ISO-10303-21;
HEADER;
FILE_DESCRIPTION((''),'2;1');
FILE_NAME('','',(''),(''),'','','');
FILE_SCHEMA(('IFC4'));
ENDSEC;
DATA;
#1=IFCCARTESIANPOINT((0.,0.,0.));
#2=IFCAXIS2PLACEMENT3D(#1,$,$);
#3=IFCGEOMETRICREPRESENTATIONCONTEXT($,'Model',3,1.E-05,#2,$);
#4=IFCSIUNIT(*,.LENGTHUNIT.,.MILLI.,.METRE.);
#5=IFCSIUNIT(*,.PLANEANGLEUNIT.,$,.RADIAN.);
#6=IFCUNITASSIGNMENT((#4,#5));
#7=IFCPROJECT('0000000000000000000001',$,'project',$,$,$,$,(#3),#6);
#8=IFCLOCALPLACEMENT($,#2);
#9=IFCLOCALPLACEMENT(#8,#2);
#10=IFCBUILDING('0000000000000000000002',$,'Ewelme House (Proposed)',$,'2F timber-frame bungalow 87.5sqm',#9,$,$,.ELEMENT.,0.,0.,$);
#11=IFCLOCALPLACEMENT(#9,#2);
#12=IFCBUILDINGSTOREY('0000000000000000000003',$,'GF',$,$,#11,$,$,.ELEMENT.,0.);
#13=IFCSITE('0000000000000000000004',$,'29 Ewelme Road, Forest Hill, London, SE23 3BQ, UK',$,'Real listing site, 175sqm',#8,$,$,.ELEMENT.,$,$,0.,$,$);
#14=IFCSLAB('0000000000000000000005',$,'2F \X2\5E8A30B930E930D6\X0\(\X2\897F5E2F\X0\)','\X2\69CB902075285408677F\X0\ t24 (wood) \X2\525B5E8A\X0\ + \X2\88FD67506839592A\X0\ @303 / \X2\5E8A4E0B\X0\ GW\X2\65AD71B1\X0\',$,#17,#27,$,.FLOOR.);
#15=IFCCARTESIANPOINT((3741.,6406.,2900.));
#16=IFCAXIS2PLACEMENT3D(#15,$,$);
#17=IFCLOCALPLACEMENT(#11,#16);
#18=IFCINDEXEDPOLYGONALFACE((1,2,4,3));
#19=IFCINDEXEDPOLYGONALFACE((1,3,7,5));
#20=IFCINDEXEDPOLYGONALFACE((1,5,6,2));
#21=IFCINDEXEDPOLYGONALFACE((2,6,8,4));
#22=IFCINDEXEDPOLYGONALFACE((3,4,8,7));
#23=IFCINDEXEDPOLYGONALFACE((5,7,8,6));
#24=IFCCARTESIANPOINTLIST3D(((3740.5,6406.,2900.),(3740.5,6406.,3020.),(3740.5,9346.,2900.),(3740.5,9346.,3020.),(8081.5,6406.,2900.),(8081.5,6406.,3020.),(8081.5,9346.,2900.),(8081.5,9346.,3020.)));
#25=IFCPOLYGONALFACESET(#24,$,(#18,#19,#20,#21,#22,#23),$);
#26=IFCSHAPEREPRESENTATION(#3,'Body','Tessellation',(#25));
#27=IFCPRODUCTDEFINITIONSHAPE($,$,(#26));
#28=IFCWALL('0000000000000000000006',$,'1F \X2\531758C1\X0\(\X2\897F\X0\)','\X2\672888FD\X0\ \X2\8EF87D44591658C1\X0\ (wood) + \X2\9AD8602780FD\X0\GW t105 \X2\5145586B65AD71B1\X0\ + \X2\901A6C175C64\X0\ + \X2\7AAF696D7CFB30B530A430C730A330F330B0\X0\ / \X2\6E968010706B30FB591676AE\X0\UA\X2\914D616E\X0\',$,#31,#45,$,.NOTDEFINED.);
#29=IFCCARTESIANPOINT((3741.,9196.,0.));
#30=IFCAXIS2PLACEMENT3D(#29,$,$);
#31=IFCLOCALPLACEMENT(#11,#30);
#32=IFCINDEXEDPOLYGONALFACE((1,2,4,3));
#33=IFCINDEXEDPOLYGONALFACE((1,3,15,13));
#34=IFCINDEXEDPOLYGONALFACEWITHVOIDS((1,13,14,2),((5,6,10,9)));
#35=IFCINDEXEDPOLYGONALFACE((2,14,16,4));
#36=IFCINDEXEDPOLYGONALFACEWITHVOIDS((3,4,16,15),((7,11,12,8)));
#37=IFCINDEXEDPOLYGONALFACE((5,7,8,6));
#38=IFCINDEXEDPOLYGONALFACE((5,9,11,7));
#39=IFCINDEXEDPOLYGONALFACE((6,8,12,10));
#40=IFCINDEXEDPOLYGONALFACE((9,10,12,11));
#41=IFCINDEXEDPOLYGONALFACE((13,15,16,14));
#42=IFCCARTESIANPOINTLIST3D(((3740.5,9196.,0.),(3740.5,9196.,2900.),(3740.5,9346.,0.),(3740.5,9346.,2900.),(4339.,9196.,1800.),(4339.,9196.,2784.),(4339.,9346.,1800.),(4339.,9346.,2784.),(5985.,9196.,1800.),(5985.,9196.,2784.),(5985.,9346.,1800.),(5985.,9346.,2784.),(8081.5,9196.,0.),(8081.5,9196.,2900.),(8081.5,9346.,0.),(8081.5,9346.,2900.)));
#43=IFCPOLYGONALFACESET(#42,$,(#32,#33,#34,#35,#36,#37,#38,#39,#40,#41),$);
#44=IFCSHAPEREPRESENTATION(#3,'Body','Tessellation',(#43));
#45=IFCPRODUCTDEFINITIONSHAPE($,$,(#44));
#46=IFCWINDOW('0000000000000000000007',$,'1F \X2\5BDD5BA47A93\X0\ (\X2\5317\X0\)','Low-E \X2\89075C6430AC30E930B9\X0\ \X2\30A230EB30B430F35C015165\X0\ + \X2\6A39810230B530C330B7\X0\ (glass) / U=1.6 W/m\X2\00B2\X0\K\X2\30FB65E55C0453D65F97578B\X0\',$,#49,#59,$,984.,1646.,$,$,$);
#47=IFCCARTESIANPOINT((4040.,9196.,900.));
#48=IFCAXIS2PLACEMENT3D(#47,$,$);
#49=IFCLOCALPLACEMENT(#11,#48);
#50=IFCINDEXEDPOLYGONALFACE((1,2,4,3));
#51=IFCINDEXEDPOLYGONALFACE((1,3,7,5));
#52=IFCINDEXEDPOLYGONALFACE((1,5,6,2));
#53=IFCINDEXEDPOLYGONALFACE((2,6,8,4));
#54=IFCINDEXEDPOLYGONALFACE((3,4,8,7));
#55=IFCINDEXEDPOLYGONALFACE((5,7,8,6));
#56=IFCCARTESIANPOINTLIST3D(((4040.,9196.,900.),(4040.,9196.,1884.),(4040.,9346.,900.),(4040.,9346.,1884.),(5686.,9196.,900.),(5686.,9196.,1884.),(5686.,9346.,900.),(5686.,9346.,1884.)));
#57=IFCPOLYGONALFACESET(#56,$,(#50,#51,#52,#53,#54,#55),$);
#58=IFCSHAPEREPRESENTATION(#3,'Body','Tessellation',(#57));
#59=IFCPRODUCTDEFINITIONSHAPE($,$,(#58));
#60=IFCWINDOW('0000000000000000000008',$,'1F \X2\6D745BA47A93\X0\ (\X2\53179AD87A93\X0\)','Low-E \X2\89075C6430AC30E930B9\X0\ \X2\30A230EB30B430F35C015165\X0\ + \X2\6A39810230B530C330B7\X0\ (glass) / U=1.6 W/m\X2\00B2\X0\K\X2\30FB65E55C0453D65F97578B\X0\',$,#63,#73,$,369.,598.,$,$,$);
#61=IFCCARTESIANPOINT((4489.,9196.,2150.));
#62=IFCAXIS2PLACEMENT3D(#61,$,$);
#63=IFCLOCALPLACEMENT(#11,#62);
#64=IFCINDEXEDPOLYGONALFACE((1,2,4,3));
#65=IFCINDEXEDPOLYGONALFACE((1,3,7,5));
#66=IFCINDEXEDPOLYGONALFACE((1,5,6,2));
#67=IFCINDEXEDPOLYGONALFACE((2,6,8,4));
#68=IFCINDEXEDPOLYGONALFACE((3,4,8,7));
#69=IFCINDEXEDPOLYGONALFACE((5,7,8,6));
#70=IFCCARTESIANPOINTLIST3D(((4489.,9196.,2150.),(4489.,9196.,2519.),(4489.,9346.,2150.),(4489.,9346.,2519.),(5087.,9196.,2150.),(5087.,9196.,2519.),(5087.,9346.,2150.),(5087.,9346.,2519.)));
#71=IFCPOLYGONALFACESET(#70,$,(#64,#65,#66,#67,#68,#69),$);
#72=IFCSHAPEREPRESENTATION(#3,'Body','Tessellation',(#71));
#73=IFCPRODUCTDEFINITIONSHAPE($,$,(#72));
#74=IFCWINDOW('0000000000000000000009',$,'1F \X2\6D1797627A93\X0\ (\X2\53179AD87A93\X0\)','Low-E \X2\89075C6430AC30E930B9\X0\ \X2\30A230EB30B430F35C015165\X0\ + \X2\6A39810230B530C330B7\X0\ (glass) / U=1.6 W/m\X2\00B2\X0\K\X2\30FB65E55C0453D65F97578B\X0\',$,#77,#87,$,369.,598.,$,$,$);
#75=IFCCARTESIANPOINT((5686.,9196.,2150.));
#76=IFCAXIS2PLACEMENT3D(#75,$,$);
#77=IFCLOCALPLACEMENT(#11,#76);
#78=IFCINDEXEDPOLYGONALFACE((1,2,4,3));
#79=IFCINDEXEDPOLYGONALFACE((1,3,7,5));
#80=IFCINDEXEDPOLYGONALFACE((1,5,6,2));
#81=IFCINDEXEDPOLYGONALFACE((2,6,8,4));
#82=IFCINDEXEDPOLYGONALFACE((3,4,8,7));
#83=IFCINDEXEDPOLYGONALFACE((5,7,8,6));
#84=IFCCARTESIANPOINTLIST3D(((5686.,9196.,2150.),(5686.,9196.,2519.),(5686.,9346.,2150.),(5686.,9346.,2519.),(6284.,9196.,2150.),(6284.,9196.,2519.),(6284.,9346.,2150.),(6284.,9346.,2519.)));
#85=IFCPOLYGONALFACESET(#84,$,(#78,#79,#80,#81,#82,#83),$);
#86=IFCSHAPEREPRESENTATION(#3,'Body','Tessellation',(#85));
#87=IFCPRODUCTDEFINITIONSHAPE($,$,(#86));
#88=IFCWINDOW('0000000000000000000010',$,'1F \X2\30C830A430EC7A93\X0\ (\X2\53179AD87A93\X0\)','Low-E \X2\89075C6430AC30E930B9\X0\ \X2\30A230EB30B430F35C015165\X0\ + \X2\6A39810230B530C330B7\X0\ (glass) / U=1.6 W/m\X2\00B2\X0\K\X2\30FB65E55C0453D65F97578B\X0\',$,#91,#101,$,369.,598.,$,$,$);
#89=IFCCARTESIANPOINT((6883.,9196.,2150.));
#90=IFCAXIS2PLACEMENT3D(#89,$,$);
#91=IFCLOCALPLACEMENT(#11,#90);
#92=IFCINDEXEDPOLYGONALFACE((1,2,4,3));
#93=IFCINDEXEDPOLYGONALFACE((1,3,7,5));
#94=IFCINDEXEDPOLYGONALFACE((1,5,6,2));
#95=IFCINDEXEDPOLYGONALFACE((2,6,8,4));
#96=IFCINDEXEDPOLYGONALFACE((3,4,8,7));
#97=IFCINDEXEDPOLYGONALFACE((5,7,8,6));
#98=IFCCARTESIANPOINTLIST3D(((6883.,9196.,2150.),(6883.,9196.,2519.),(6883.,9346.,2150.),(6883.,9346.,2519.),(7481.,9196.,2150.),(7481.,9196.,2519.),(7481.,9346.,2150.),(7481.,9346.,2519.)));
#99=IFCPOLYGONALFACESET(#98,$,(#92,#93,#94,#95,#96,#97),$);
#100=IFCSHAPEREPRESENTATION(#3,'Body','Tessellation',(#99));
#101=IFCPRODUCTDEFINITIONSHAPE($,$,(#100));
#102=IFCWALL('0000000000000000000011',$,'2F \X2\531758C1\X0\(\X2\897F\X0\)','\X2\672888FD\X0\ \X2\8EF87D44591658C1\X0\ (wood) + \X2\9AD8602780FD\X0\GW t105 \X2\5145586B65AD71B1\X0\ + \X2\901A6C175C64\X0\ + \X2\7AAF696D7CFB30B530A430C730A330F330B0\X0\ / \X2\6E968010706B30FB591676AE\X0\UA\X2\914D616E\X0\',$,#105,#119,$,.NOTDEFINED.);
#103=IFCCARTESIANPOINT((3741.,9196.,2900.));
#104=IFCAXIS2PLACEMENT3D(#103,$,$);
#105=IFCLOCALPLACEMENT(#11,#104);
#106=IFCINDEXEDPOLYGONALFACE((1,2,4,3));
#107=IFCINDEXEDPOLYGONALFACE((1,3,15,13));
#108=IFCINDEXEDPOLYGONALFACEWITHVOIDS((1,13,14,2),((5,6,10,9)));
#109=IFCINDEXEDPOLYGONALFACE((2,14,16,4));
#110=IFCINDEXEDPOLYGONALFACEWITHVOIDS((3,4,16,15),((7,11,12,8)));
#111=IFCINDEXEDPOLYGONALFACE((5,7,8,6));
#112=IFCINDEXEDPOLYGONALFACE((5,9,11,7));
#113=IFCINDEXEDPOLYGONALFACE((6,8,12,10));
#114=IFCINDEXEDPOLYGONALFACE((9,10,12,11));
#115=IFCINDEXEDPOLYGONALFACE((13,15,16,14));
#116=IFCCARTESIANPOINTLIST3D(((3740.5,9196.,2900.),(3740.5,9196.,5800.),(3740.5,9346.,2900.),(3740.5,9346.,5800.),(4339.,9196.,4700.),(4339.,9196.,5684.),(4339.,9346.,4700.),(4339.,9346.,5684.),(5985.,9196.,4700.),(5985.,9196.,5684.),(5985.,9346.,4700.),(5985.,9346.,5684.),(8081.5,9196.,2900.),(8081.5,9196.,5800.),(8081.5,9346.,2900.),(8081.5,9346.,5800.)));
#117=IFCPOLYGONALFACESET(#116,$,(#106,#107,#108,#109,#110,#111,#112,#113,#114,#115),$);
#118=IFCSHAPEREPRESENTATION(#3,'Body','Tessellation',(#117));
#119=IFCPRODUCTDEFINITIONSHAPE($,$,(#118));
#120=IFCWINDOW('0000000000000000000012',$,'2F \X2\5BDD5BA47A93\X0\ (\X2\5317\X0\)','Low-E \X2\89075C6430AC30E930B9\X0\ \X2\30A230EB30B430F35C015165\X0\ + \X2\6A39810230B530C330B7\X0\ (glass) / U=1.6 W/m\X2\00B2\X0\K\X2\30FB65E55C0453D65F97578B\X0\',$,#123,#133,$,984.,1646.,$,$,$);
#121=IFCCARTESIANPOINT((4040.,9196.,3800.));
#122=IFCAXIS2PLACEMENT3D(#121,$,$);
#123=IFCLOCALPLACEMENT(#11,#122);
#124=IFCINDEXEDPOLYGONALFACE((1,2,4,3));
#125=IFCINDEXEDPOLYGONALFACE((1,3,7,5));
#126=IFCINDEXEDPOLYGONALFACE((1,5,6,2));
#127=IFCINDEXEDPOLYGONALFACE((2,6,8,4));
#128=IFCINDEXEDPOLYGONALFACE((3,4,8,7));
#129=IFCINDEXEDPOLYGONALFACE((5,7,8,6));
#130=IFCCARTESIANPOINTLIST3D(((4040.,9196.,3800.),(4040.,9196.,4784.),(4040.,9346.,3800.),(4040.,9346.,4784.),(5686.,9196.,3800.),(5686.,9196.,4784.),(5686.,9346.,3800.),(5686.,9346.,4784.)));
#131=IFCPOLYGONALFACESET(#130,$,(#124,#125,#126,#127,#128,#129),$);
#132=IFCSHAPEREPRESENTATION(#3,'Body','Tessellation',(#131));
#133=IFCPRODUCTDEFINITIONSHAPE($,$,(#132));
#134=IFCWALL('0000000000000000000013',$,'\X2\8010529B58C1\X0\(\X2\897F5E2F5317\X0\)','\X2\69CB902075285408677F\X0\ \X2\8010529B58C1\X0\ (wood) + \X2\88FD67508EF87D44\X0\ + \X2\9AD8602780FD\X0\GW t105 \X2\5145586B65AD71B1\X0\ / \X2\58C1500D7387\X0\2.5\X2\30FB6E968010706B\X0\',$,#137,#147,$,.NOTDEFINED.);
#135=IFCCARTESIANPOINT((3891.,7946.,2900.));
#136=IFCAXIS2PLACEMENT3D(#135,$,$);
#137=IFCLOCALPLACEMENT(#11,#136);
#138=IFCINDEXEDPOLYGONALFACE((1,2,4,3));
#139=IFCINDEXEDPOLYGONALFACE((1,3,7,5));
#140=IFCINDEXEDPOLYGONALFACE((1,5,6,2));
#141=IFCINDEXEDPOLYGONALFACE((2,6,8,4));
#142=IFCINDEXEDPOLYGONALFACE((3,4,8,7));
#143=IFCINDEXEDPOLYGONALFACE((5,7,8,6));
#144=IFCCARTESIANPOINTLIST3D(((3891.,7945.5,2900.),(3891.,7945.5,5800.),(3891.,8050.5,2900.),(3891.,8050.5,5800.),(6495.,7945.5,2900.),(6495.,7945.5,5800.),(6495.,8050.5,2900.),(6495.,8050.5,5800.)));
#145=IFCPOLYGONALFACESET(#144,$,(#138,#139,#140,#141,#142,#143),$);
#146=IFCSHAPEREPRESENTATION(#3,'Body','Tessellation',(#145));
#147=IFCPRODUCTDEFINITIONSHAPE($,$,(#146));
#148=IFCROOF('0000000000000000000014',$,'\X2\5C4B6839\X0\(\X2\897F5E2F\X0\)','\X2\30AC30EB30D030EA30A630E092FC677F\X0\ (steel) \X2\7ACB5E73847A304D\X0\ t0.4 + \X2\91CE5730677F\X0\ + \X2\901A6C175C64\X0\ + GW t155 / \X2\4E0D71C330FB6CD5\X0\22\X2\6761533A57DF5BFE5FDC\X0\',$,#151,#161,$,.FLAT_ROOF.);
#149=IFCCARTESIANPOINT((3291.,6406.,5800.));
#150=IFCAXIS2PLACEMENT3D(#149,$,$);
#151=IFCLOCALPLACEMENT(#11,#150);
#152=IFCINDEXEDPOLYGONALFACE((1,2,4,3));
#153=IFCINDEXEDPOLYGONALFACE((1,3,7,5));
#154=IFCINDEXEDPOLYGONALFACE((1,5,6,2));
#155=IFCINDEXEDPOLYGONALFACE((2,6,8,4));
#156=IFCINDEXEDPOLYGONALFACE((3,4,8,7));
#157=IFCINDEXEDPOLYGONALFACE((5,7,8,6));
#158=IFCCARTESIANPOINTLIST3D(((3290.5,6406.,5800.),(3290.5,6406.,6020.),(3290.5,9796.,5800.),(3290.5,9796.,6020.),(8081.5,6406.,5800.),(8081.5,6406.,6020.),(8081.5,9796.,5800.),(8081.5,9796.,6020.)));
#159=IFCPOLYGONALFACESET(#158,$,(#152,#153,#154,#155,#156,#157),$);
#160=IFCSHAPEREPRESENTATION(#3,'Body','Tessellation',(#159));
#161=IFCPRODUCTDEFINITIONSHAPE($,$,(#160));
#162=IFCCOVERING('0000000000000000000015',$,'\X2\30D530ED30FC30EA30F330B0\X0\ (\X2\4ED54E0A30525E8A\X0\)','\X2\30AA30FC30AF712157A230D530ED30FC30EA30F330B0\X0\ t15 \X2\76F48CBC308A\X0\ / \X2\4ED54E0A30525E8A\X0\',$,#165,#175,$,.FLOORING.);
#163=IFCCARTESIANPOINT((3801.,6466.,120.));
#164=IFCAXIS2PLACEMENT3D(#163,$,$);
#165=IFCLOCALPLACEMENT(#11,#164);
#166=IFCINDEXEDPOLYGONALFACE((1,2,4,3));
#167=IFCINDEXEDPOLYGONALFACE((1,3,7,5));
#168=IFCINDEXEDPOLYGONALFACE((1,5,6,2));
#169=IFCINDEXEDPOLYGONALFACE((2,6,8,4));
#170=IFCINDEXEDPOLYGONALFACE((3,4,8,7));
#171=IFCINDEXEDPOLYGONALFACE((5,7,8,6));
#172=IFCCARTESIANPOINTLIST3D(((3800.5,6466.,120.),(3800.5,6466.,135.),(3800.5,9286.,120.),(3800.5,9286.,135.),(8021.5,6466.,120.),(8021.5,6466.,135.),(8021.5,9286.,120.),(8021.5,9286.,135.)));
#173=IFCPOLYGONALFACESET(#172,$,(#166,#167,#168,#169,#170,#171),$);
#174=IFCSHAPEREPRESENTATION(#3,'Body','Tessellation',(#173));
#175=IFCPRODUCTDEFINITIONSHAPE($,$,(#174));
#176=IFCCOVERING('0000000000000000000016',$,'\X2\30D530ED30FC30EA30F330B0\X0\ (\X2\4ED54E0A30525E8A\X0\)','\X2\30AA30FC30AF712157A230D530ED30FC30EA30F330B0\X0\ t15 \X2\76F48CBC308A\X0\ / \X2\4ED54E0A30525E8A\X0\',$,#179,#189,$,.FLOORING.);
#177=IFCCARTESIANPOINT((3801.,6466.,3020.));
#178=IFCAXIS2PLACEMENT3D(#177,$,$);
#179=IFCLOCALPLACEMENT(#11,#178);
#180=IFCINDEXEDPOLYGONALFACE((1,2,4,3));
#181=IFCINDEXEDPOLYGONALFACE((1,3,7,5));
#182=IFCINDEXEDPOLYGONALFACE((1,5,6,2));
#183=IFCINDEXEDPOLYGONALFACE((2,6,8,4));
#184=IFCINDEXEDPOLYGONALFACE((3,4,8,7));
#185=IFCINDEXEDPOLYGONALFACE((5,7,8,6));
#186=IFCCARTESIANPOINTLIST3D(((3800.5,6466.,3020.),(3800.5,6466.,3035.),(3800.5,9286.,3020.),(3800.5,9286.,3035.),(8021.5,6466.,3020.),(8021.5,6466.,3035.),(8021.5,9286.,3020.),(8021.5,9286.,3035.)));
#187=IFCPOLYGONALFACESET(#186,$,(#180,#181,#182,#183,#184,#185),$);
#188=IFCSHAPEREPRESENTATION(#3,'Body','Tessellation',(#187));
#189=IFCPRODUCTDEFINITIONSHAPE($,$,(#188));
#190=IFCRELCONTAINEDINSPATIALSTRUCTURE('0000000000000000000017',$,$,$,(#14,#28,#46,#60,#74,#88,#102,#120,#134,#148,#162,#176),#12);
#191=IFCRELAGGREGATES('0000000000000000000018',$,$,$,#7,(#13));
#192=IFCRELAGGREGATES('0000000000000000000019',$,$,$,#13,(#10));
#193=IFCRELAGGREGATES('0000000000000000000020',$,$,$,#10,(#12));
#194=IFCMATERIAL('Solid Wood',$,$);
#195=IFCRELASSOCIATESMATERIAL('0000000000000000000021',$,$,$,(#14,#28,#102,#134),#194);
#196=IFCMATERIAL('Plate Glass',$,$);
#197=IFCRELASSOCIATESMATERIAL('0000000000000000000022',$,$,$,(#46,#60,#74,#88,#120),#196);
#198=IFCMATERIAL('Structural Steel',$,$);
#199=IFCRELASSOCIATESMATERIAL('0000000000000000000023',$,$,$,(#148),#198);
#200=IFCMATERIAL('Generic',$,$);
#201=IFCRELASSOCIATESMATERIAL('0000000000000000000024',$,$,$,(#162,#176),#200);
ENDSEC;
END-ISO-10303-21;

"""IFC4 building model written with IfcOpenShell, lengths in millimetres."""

from ifc_helpers import new_model, si_unit, frame, frame_2d, origin, place, context, project, spatial, rectangle, extrude, material, element, fill, save


model = new_model("IFC4")

# Units and contexts
model_context = context("Model", 3, precision=1e-05, world=origin())
ifc_project = project(units=[si_unit("LENGTHUNIT", "METRE", prefix="MILLI"), si_unit("PLANEANGLEUNIT", "RADIAN")], contexts=[model_context])

# Site, building, storey
site_placement = place(None, origin())
site = spatial("IfcSite", under=ifc_project, at=site_placement, Name="29 Ewelme Road, Forest Hill, London, SE23 3BQ, UK", ObjectType="Real listing site, 175sqm", CompositionType="ELEMENT", RefElevation=0.0)
building_placement = place(site_placement, origin())
building = spatial("IfcBuilding", under=site, at=building_placement, Name="Ewelme House (Proposed)", ObjectType="2F timber-frame bungalow 87.5sqm", CompositionType="ELEMENT", ElevationOfRefHeight=0.0, ElevationOfTerrain=0.0)
storey_placement = place(building_placement, origin())
storey = spatial("IfcBuildingStorey", under=building, at=storey_placement, Name="GF", CompositionType="ELEMENT", Elevation=0.0)

# Slab
ifc_material_1 = material(Name="Solid Wood")
slab_1_placement = place(storey_placement, frame((3741.0, 6406.0, 2900.0)))
element("IfcSlab", 1, at=slab_1_placement, inside=storey, material=ifc_material_1, Name="2F 床スラブ(西帯)", Description="構造用合板 t24 (wood) 剛床 + 製材根太 @303 / 床下 GW断熱", PredefinedType="FLOOR", context=model_context, shape_type="SweptSolid", body=[
    extrude(rectangle(XDim=4341.0, YDim=2940.0, at=frame_2d((2170.0, 1470.0))), frame((3741.0, 6406.0, 2900.0)), (0.0, 0.0, 1.0), 120.0),
])

# Wall, openings, windows
wall_1_placement = place(storey_placement, frame((3741.0, 9196.0, 0.0)))
wall_1 = element("IfcWall", 2, at=wall_1_placement, inside=storey, material=ifc_material_1, Name="1F 北壁(西)", Description="木製 軸組外壁 (wood) + 高性能GW t105 充填断熱 + 通気層 + 窯業系サイディング / 準耐火・外皮UA配慮", PredefinedType="NOTDEFINED", context=model_context, shape_type="SweptSolid", body=[
    extrude(rectangle(XDim=4341.0, YDim=150.0, at=frame_2d((2170.0, 75.0))), frame((3741.0, 9196.0, 0.0)), (0.0, 0.0, 1.0), 2900.0),
])
opening_1_placement = place(storey_placement, frame((4040.0, 9196.0, 900.0)))
opening_1 = element("IfcOpeningElement", 3, at=opening_1_placement, cuts=wall_1, PredefinedType="NOTDEFINED", context=model_context, shape_type="SweptSolid", body=[
    extrude(rectangle(XDim=1646.0, YDim=150.0, at=frame_2d((823.0, 75.0))), frame((4040.0, 9196.0, 900.0)), (0.0, 0.0, 1.0), 984.0),
])
opening_2_placement = place(storey_placement, frame((4489.0, 9196.0, 2150.0)))
opening_2 = element("IfcOpeningElement", 4, at=opening_2_placement, cuts=wall_1, PredefinedType="NOTDEFINED", context=model_context, shape_type="SweptSolid", body=[
    extrude(rectangle(XDim=598.0, YDim=150.0, at=frame_2d((299.0, 75.0))), frame((4489.0, 9196.0, 2150.0)), (0.0, 0.0, 1.0), 369.0),
])
opening_3_placement = place(storey_placement, frame((5686.0, 9196.0, 2150.0)))
opening_3 = element("IfcOpeningElement", 5, at=opening_3_placement, cuts=wall_1, PredefinedType="NOTDEFINED", context=model_context, shape_type="SweptSolid", body=[
    extrude(rectangle(XDim=598.0, YDim=150.0, at=frame_2d((299.0, 75.0))), frame((5686.0, 9196.0, 2150.0)), (0.0, 0.0, 1.0), 369.0),
])
opening_4_placement = place(storey_placement, frame((6883.0, 9196.0, 2150.0)))
opening_4 = element("IfcOpeningElement", 6, at=opening_4_placement, cuts=wall_1, PredefinedType="NOTDEFINED", context=model_context, shape_type="SweptSolid", body=[
    extrude(rectangle(XDim=598.0, YDim=150.0, at=frame_2d((299.0, 75.0))), frame((6883.0, 9196.0, 2150.0)), (0.0, 0.0, 1.0), 369.0),
])
ifc_material_2 = material(Name="Plate Glass")
window_1_placement = place(storey_placement, frame((4040.0, 9196.0, 900.0)))
window_1 = element("IfcWindow", 7, at=window_1_placement, inside=storey, material=ifc_material_2, Name="1F 寝室窓 (北)", Description="Low-E 複層ガラス アルゴン封入 + 樹脂サッシ (glass) / U=1.6 W/m²K・日射取得型", OverallHeight=984.0, OverallWidth=1646.0, context=model_context, shape_type="SweptSolid", body=[
    extrude(rectangle(XDim=1646.0, YDim=150.0, at=frame_2d((823.0, 75.0))), frame((4040.0, 9196.0, 900.0)), (0.0, 0.0, 1.0), 984.0),
])
fill(opening_1, window_1)
window_2_placement = place(storey_placement, frame((4489.0, 9196.0, 2150.0)))
window_2 = element("IfcWindow", 8, at=window_2_placement, inside=storey, material=ifc_material_2, Name="1F 浴室窓 (北高窓)", Description="Low-E 複層ガラス アルゴン封入 + 樹脂サッシ (glass) / U=1.6 W/m²K・日射取得型", OverallHeight=369.0, OverallWidth=598.0, context=model_context, shape_type="SweptSolid", body=[
    extrude(rectangle(XDim=598.0, YDim=150.0, at=frame_2d((299.0, 75.0))), frame((4489.0, 9196.0, 2150.0)), (0.0, 0.0, 1.0), 369.0),
])
fill(opening_2, window_2)
window_3_placement = place(storey_placement, frame((5686.0, 9196.0, 2150.0)))
window_3 = element("IfcWindow", 9, at=window_3_placement, inside=storey, material=ifc_material_2, Name="1F 洗面窓 (北高窓)", Description="Low-E 複層ガラス アルゴン封入 + 樹脂サッシ (glass) / U=1.6 W/m²K・日射取得型", OverallHeight=369.0, OverallWidth=598.0, context=model_context, shape_type="SweptSolid", body=[
    extrude(rectangle(XDim=598.0, YDim=150.0, at=frame_2d((299.0, 75.0))), frame((5686.0, 9196.0, 2150.0)), (0.0, 0.0, 1.0), 369.0),
])
fill(opening_3, window_3)
window_4_placement = place(storey_placement, frame((6883.0, 9196.0, 2150.0)))
window_4 = element("IfcWindow", 10, at=window_4_placement, inside=storey, material=ifc_material_2, Name="1F トイレ窓 (北高窓)", Description="Low-E 複層ガラス アルゴン封入 + 樹脂サッシ (glass) / U=1.6 W/m²K・日射取得型", OverallHeight=369.0, OverallWidth=598.0, context=model_context, shape_type="SweptSolid", body=[
    extrude(rectangle(XDim=598.0, YDim=150.0, at=frame_2d((299.0, 75.0))), frame((6883.0, 9196.0, 2150.0)), (0.0, 0.0, 1.0), 369.0),
])
fill(opening_4, window_4)

# Wall, opening, window
wall_2_placement = place(storey_placement, frame((3741.0, 9196.0, 2900.0)))
wall_2 = element("IfcWall", 11, at=wall_2_placement, inside=storey, material=ifc_material_1, Name="2F 北壁(西)", Description="木製 軸組外壁 (wood) + 高性能GW t105 充填断熱 + 通気層 + 窯業系サイディング / 準耐火・外皮UA配慮", PredefinedType="NOTDEFINED", context=model_context, shape_type="SweptSolid", body=[
    extrude(rectangle(XDim=4341.0, YDim=150.0, at=frame_2d((2170.0, 75.0))), frame((3741.0, 9196.0, 2900.0)), (0.0, 0.0, 1.0), 2900.0),
])
opening_5_placement = place(storey_placement, frame((4040.0, 9196.0, 3800.0)))
opening_5 = element("IfcOpeningElement", 12, at=opening_5_placement, cuts=wall_2, PredefinedType="NOTDEFINED", context=model_context, shape_type="SweptSolid", body=[
    extrude(rectangle(XDim=1646.0, YDim=150.0, at=frame_2d((823.0, 75.0))), frame((4040.0, 9196.0, 3800.0)), (0.0, 0.0, 1.0), 984.0),
])
window_5_placement = place(storey_placement, frame((4040.0, 9196.0, 3800.0)))
window_5 = element("IfcWindow", 13, at=window_5_placement, inside=storey, material=ifc_material_2, Name="2F 寝室窓 (北)", Description="Low-E 複層ガラス アルゴン封入 + 樹脂サッシ (glass) / U=1.6 W/m²K・日射取得型", OverallHeight=984.0, OverallWidth=1646.0, context=model_context, shape_type="SweptSolid", body=[
    extrude(rectangle(XDim=1646.0, YDim=150.0, at=frame_2d((823.0, 75.0))), frame((4040.0, 9196.0, 3800.0)), (0.0, 0.0, 1.0), 984.0),
])
fill(opening_5, window_5)

# Wall
wall_3_placement = place(storey_placement, frame((3891.0, 7946.0, 2900.0)))
element("IfcWall", 14, at=wall_3_placement, inside=storey, material=ifc_material_1, Name="耐力壁(西帯北)", Description="構造用合板 耐力壁 (wood) + 製材軸組 + 高性能GW t105 充填断熱 / 壁倍率2.5・準耐火", PredefinedType="NOTDEFINED", context=model_context, shape_type="SweptSolid", body=[
    extrude(rectangle(XDim=2604.0, YDim=105.0, at=frame_2d((1302.0, 52.0))), frame((3891.0, 7946.0, 2900.0)), (0.0, 0.0, 1.0), 2900.0),
])

# Roof
ifc_material_3 = material(Name="Structural Steel")
for number, where, name in (
    (15, (3291.0, 6406.0, 5800.0), "屋根(西帯)"),
):
    element("IfcRoof", number, at=place(storey_placement, frame(where)), inside=storey, material=ifc_material_3, Name=name, Description="ガルバリウム鋼板 (steel) 立平葺き t0.4 + 野地板 + 通気層 + GW t155 / 不燃・法22条区域対応", PredefinedType="FLAT_ROOF", context=model_context, shape_type="SweptSolid", body=[
        extrude(rectangle(XDim=4791.0, YDim=3390.0, at=frame_2d((2395.0, 1695.0))), frame((3291.0, 6406.0, 5800.0)), (0.0, 0.0, 1.0), 220.0),
    ])

# Coverings
ifc_material_4 = material(Name="Generic")
covering_1_placement = place(storey_placement, frame((3801.0, 6466.0, 120.0)))
element("IfcCovering", 16, at=covering_1_placement, inside=storey, material=ifc_material_4, Name="フローリング (仕上げ床)", Description="オーク無垢フローリング t15 直貼り / 仕上げ床", PredefinedType="FLOORING", context=model_context, shape_type="SweptSolid", body=[
    extrude(rectangle(XDim=4221.0, YDim=2820.0, at=frame_2d((2110.0, 1410.0))), frame((3801.0, 6466.0, 120.0)), (0.0, 0.0, 1.0), 15.0),
])
covering_2_placement = place(storey_placement, frame((3801.0, 6466.0, 3020.0)))
element("IfcCovering", 17, at=covering_2_placement, inside=storey, material=ifc_material_4, Name="フローリング (仕上げ床)", Description="オーク無垢フローリング t15 直貼り / 仕上げ床", PredefinedType="FLOORING", context=model_context, shape_type="SweptSolid", body=[
    extrude(rectangle(XDim=4221.0, YDim=2820.0, at=frame_2d((2110.0, 1410.0))), frame((3801.0, 6466.0, 3020.0)), (0.0, 0.0, 1.0), 15.0),
])

save(model, "model.ifc")
